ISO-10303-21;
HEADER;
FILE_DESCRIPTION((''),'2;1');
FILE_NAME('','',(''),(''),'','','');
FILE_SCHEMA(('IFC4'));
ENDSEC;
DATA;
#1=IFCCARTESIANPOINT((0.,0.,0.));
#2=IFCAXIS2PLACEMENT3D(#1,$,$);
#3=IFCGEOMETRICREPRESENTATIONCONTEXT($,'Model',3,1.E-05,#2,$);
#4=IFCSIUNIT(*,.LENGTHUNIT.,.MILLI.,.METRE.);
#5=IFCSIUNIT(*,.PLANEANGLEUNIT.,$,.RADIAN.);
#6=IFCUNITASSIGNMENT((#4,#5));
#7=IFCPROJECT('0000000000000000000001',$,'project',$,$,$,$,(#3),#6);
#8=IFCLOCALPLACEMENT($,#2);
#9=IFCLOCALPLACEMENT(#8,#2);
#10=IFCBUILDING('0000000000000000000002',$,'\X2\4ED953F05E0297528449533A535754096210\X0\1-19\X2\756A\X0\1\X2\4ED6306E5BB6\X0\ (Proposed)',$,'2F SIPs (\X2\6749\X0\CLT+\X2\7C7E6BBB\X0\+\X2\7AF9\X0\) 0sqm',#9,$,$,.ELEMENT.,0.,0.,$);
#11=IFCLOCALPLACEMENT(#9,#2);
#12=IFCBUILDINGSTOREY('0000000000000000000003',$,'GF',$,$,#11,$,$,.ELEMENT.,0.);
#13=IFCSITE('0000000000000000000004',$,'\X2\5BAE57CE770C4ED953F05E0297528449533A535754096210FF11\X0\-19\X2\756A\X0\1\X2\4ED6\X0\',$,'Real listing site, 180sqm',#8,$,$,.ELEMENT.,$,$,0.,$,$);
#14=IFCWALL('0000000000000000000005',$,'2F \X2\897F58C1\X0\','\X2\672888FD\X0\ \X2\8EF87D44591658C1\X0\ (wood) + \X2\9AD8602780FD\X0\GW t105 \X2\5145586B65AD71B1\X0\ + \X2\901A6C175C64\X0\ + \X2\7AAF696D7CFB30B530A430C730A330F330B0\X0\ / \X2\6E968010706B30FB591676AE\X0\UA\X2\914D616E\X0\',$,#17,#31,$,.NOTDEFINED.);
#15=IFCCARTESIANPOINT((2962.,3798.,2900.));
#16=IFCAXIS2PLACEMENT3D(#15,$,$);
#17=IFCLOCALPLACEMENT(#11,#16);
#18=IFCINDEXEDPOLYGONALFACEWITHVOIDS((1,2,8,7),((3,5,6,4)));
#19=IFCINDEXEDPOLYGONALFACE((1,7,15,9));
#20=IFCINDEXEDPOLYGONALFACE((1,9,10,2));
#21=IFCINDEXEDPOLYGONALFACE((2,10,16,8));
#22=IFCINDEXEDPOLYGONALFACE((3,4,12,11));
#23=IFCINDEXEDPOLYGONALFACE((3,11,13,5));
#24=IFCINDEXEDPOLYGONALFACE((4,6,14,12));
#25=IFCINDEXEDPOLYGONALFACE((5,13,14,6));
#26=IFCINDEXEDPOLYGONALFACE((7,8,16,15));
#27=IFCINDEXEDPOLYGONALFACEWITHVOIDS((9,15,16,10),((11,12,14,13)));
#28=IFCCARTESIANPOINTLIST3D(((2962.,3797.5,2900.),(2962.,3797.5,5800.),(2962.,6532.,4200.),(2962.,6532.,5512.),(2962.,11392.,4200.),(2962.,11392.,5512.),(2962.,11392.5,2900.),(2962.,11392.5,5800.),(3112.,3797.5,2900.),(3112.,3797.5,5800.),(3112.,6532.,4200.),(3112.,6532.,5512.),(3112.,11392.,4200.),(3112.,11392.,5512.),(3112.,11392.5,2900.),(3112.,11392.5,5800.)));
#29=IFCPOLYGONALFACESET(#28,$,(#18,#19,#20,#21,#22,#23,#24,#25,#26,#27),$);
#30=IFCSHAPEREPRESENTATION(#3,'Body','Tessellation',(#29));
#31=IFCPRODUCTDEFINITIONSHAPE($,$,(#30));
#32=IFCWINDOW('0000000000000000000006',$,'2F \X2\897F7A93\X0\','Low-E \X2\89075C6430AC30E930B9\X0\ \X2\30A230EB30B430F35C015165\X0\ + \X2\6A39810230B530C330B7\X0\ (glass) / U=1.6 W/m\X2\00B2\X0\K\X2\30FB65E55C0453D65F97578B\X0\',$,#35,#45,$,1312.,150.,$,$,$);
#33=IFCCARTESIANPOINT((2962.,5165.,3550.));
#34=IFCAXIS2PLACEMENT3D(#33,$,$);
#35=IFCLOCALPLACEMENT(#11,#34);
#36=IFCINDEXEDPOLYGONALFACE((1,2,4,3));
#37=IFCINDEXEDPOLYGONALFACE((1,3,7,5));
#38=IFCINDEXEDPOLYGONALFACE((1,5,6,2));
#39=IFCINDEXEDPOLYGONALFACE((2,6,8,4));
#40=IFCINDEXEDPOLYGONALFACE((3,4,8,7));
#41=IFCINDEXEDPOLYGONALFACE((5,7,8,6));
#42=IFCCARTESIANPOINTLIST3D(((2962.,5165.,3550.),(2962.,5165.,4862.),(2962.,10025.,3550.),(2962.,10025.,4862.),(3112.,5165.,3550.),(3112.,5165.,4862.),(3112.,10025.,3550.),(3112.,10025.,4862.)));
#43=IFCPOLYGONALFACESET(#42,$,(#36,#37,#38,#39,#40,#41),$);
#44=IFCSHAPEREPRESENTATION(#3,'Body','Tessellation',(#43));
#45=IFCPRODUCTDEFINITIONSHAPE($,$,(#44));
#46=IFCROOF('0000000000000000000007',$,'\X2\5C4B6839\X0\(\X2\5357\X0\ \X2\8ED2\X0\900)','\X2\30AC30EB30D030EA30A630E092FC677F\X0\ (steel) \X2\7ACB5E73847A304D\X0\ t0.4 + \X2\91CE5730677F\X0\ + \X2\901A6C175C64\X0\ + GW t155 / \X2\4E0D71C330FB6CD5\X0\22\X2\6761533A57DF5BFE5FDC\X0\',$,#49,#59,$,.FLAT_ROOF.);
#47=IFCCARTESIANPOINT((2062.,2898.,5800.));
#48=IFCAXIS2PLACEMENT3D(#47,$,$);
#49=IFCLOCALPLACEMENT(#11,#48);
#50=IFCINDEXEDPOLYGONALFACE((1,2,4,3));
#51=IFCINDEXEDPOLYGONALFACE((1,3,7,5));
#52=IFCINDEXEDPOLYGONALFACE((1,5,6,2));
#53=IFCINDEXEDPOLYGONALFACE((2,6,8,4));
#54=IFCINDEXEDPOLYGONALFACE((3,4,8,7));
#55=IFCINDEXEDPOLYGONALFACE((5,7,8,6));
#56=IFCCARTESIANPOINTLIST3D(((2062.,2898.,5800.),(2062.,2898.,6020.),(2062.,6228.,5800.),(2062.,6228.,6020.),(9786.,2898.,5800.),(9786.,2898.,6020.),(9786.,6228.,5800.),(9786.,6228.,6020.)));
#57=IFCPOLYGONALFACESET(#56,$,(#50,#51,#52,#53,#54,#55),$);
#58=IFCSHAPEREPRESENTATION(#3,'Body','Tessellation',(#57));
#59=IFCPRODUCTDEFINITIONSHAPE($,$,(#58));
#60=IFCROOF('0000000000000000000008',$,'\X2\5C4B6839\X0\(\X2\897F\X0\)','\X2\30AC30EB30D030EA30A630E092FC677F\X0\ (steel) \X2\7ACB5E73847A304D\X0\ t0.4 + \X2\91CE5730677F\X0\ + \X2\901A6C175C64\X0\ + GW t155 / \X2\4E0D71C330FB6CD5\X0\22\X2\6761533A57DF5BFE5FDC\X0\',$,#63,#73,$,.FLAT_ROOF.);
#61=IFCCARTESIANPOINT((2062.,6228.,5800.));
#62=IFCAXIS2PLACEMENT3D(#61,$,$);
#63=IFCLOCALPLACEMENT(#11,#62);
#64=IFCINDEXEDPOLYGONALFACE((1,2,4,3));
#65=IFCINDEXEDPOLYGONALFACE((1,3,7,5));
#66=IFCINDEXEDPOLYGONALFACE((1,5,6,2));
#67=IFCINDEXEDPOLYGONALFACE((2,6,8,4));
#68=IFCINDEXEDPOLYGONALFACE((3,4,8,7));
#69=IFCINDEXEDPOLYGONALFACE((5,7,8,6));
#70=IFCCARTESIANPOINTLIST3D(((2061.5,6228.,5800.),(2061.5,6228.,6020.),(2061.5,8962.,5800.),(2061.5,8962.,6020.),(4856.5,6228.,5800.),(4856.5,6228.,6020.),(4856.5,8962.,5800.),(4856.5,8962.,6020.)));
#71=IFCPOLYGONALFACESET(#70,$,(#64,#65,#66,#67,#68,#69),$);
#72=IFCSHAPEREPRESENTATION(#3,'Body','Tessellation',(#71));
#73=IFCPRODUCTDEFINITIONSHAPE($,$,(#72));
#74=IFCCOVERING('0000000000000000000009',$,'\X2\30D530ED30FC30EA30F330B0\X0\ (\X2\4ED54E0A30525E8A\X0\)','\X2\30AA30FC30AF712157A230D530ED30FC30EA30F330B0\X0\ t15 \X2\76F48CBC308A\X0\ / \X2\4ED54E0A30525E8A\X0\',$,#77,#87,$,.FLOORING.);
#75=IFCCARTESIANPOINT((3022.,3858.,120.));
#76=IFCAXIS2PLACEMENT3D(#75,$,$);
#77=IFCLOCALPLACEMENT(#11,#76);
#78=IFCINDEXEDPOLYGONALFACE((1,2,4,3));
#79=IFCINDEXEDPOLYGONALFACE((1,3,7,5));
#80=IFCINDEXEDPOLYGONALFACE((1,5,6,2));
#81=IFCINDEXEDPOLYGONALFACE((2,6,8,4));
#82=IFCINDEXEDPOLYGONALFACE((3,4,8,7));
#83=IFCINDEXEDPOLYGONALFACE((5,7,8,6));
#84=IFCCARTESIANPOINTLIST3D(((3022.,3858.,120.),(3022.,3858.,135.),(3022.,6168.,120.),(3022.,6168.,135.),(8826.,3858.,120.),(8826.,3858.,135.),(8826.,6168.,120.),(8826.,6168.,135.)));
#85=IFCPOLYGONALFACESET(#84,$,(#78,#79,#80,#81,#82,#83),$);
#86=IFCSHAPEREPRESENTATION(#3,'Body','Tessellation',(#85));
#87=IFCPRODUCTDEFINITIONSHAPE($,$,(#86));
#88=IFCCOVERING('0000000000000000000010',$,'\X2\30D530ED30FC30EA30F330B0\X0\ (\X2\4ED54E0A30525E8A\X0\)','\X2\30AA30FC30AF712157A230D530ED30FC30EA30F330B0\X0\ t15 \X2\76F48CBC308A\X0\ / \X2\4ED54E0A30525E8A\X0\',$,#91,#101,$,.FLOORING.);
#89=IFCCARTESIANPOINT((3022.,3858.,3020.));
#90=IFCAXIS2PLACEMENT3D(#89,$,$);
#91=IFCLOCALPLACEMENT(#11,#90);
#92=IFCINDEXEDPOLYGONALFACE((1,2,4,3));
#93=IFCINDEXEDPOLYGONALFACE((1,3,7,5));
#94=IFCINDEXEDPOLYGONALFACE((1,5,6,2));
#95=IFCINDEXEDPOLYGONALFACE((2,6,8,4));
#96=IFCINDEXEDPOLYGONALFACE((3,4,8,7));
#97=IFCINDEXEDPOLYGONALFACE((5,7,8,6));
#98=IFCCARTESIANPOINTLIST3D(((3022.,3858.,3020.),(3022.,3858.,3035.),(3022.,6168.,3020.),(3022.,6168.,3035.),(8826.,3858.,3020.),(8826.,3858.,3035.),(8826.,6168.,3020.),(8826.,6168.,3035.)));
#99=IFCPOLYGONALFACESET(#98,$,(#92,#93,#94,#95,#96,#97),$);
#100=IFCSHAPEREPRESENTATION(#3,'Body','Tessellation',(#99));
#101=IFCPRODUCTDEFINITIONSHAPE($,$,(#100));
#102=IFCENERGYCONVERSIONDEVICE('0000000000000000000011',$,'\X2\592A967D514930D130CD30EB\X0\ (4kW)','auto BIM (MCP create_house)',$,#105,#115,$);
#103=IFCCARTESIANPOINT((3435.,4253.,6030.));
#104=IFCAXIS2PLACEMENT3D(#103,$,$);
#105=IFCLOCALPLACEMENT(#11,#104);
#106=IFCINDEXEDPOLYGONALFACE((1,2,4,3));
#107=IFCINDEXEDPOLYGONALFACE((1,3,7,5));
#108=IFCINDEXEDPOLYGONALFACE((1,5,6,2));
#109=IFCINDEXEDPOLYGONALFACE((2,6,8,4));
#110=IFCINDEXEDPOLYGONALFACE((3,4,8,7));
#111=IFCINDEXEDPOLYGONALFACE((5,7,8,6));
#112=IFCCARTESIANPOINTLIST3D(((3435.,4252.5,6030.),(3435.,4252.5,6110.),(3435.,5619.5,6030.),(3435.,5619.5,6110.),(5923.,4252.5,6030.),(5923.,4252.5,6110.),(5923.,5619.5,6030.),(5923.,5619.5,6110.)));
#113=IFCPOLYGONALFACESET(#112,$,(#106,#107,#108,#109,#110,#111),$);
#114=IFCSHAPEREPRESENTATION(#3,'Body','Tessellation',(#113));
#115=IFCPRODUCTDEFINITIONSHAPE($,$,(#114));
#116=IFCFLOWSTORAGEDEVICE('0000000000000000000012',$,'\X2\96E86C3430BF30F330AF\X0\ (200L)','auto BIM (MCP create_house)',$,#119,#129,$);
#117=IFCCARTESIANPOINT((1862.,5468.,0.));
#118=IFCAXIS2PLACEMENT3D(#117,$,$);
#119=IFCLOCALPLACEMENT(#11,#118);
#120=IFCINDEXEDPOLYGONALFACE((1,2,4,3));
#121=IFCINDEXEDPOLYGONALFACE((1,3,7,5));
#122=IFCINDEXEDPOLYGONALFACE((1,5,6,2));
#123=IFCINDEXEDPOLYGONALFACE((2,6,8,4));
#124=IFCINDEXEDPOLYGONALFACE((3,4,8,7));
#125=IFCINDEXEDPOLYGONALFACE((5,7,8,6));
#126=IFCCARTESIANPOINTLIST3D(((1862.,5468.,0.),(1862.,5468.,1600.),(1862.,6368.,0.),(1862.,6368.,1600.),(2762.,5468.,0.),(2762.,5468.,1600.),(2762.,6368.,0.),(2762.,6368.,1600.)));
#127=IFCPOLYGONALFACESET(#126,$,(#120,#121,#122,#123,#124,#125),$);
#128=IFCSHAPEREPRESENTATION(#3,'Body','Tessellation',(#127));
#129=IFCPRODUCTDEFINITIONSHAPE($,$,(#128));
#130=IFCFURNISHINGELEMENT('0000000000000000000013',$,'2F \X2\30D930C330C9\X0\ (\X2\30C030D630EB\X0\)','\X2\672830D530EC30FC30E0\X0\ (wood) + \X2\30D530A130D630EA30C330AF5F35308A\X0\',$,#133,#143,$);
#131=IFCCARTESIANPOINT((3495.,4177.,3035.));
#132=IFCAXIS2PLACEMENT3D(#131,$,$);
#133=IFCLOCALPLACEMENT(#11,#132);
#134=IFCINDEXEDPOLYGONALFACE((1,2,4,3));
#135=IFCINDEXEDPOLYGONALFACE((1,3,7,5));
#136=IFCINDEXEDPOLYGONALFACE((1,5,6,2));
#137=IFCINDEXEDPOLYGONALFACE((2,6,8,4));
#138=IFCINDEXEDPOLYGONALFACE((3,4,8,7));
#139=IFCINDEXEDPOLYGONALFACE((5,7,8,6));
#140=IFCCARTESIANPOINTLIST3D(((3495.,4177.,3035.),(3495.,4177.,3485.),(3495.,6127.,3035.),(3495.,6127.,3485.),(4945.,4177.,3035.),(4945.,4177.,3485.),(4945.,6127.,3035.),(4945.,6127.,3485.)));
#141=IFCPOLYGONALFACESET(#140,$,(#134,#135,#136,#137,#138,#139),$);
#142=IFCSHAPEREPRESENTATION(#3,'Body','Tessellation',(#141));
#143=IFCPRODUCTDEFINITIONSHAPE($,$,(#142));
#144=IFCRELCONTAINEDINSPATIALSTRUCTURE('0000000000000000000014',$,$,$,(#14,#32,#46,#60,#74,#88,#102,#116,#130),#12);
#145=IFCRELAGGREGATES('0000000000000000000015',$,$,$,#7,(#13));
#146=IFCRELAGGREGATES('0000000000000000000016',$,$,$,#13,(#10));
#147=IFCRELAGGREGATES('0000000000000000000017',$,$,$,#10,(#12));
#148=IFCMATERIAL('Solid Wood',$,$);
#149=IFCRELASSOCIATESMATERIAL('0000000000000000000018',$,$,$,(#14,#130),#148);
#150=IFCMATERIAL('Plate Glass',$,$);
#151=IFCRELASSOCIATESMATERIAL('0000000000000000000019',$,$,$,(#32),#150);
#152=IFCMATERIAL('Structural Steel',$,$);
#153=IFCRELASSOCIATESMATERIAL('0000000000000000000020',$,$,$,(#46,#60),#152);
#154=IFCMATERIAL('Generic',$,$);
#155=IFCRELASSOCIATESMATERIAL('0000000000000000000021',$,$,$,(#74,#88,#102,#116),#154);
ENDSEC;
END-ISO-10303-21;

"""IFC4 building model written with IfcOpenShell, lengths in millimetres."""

from ifc_helpers import new_model, si_unit, frame, frame_2d, origin, place, context, project, spatial, rectangle, extrude, material, element, fill, save


model = new_model("IFC4")

# Units and contexts
model_context = context("Model", 3, precision=1e-05, world=origin())
ifc_project = project(units=[si_unit("LENGTHUNIT", "METRE", prefix="MILLI"), si_unit("PLANEANGLEUNIT", "RADIAN")], contexts=[model_context])

# Site, building, storey
site_placement = place(None, origin())
site = spatial("IfcSite", under=ifc_project, at=site_placement, Name="宮城県仙台市青葉区南吉成１-19番1他", ObjectType="Real listing site, 180sqm", CompositionType="ELEMENT", RefElevation=0.0)
building_placement = place(site_placement, origin())
building = spatial("IfcBuilding", under=site, at=building_placement, Name="仙台市青葉区南吉成1-19番1他の家 (Proposed)", ObjectType="2F SIPs (杉CLT+籾殻+竹) 0sqm", CompositionType="ELEMENT", ElevationOfRefHeight=0.0, ElevationOfTerrain=0.0)
storey_placement = place(building_placement, origin())
storey = spatial("IfcBuildingStorey", under=building, at=storey_placement, Name="GF", CompositionType="ELEMENT", Elevation=0.0)

# Shared definitions
ifc_material_1 = material(Name="Solid Wood")

# Shared definitions
ifc_material_2 = material(Name="Plate Glass")

# Wall, opening, window
wall_1_placement = place(storey_placement, frame((2962.0, 3798.0, 2900.0)))
wall_1 = element("IfcWall", 1, at=wall_1_placement, inside=storey, material=ifc_material_1, Name="2F 西壁", Description="木製 軸組外壁 (wood) + 高性能GW t105 充填断熱 + 通気層 + 窯業系サイディング / 準耐火・外皮UA配慮", PredefinedType="NOTDEFINED", context=model_context, shape_type="SweptSolid", body=[
    extrude(rectangle(XDim=150.0, YDim=7595.0, at=frame_2d((75.0, 3797.0))), frame((2962.0, 3798.0, 2900.0)), (0.0, 0.0, 1.0), 2900.0),
])
opening_1_placement = place(storey_placement, frame((2962.0, 5165.0, 3550.0)))
opening_1 = element("IfcOpeningElement", 2, at=opening_1_placement, cuts=wall_1, PredefinedType="NOTDEFINED", context=model_context, shape_type="SweptSolid", body=[
    extrude(rectangle(XDim=150.0, YDim=4860.0, at=frame_2d((75.0, 2430.0))), frame((2962.0, 5165.0, 3550.0)), (0.0, 0.0, 1.0), 1312.0),
])
window_1_placement = place(storey_placement, frame((2962.0, 5165.0, 3550.0)))
window_1 = element("IfcWindow", 3, at=window_1_placement, inside=storey, material=ifc_material_2, Name="2F 西窓", Description="Low-E 複層ガラス アルゴン封入 + 樹脂サッシ (glass) / U=1.6 W/m²K・日射取得型", OverallHeight=1312.0, OverallWidth=150.0, context=model_context, shape_type="SweptSolid", body=[
    extrude(rectangle(XDim=150.0, YDim=4860.0, at=frame_2d((75.0, 2430.0))), frame((2962.0, 5165.0, 3550.0)), (0.0, 0.0, 1.0), 1312.0),
])
fill(opening_1, window_1)

# Roofs
ifc_material_3 = material(Name="Structural Steel")
roof_1_placement = place(storey_placement, frame((2062.0, 2898.0, 5800.0)))
element("IfcRoof", 4, at=roof_1_placement, inside=storey, material=ifc_material_3, Name="屋根(南 軒900)", Description="ガルバリウム鋼板 (steel) 立平葺き t0.4 + 野地板 + 通気層 + GW t155 / 不燃・法22条区域対応", PredefinedType="FLAT_ROOF", context=model_context, shape_type="SweptSolid", body=[
    extrude(rectangle(XDim=7724.0, YDim=3330.0, at=frame_2d((3862.0, 1665.0))), frame((2062.0, 2898.0, 5800.0)), (0.0, 0.0, 1.0), 220.0),
])
roof_2_placement = place(storey_placement, frame((2062.0, 6228.0, 5800.0)))
element("IfcRoof", 5, at=roof_2_placement, inside=storey, material=ifc_material_3, Name="屋根(西)", Description="ガルバリウム鋼板 (steel) 立平葺き t0.4 + 野地板 + 通気層 + GW t155 / 不燃・法22条区域対応", PredefinedType="FLAT_ROOF", context=model_context, shape_type="SweptSolid", body=[
    extrude(rectangle(XDim=2795.0, YDim=2734.0, at=frame_2d((1397.0, 1367.0))), frame((2062.0, 6228.0, 5800.0)), (0.0, 0.0, 1.0), 220.0),
])

# Coverings
ifc_material_4 = material(Name="Generic")
covering_1_placement = place(storey_placement, frame((3022.0, 3858.0, 120.0)))
element("IfcCovering", 6, at=covering_1_placement, inside=storey, material=ifc_material_4, Name="フローリング (仕上げ床)", Description="オーク無垢フローリング t15 直貼り / 仕上げ床", PredefinedType="FLOORING", context=model_context, shape_type="SweptSolid", body=[
    extrude(rectangle(XDim=5804.0, YDim=2310.0, at=frame_2d((2902.0, 1155.0))), frame((3022.0, 3858.0, 120.0)), (0.0, 0.0, 1.0), 15.0),
])
covering_2_placement = place(storey_placement, frame((3022.0, 3858.0, 3020.0)))
element("IfcCovering", 7, at=covering_2_placement, inside=storey, material=ifc_material_4, Name="フローリング (仕上げ床)", Description="オーク無垢フローリング t15 直貼り / 仕上げ床", PredefinedType="FLOORING", context=model_context, shape_type="SweptSolid", body=[
    extrude(rectangle(XDim=5804.0, YDim=2310.0, at=frame_2d((2902.0, 1155.0))), frame((3022.0, 3858.0, 3020.0)), (0.0, 0.0, 1.0), 15.0),
])

# Energy conversion device
energy_conversion_device_placement = place(storey_placement, frame((3435.0, 4253.0, 6030.0)))
element("IfcEnergyConversionDevice", 8, at=energy_conversion_device_placement, inside=storey, material=ifc_material_4, Name="太陽光パネル (4kW)", Description="auto BIM (MCP create_house)", context=model_context, shape_type="SweptSolid", body=[
    extrude(rectangle(XDim=2488.0, YDim=1367.0, at=frame_2d((1244.0, 683.0))), frame((3435.0, 4253.0, 6030.0)), (0.0, 0.0, 1.0), 80.0),
])

# Flow storage device
flow_storage_device_placement = place(storey_placement, frame((1862.0, 5468.0, 0.0)))
element("IfcFlowStorageDevice", 9, at=flow_storage_device_placement, inside=storey, material=ifc_material_4, Name="雨水タンク (200L)", Description="auto BIM (MCP create_house)", context=model_context, shape_type="SweptSolid", body=[
    extrude(rectangle(XDim=900.0, YDim=900.0, at=frame_2d((450.0, 450.0))), frame((1862.0, 5468.0, 0.0)), (0.0, 0.0, 1.0), 1600.0),
])

# Furnishing element
furnishing_placement = place(storey_placement, frame((3495.0, 4177.0, 3035.0)))
element("IfcFurnishingElement", 10, at=furnishing_placement, inside=storey, material=ifc_material_1, Name="2F ベッド (ダブル)", Description="木フレーム (wood) + ファブリック張り", context=model_context, shape_type="SweptSolid", body=[
    extrude(rectangle(XDim=1450.0, YDim=1950.0, at=frame_2d((725.0, 975.0))), frame((3495.0, 4177.0, 3035.0)), (0.0, 0.0, 1.0), 450.0),
])

save(model, "model.ifc")
